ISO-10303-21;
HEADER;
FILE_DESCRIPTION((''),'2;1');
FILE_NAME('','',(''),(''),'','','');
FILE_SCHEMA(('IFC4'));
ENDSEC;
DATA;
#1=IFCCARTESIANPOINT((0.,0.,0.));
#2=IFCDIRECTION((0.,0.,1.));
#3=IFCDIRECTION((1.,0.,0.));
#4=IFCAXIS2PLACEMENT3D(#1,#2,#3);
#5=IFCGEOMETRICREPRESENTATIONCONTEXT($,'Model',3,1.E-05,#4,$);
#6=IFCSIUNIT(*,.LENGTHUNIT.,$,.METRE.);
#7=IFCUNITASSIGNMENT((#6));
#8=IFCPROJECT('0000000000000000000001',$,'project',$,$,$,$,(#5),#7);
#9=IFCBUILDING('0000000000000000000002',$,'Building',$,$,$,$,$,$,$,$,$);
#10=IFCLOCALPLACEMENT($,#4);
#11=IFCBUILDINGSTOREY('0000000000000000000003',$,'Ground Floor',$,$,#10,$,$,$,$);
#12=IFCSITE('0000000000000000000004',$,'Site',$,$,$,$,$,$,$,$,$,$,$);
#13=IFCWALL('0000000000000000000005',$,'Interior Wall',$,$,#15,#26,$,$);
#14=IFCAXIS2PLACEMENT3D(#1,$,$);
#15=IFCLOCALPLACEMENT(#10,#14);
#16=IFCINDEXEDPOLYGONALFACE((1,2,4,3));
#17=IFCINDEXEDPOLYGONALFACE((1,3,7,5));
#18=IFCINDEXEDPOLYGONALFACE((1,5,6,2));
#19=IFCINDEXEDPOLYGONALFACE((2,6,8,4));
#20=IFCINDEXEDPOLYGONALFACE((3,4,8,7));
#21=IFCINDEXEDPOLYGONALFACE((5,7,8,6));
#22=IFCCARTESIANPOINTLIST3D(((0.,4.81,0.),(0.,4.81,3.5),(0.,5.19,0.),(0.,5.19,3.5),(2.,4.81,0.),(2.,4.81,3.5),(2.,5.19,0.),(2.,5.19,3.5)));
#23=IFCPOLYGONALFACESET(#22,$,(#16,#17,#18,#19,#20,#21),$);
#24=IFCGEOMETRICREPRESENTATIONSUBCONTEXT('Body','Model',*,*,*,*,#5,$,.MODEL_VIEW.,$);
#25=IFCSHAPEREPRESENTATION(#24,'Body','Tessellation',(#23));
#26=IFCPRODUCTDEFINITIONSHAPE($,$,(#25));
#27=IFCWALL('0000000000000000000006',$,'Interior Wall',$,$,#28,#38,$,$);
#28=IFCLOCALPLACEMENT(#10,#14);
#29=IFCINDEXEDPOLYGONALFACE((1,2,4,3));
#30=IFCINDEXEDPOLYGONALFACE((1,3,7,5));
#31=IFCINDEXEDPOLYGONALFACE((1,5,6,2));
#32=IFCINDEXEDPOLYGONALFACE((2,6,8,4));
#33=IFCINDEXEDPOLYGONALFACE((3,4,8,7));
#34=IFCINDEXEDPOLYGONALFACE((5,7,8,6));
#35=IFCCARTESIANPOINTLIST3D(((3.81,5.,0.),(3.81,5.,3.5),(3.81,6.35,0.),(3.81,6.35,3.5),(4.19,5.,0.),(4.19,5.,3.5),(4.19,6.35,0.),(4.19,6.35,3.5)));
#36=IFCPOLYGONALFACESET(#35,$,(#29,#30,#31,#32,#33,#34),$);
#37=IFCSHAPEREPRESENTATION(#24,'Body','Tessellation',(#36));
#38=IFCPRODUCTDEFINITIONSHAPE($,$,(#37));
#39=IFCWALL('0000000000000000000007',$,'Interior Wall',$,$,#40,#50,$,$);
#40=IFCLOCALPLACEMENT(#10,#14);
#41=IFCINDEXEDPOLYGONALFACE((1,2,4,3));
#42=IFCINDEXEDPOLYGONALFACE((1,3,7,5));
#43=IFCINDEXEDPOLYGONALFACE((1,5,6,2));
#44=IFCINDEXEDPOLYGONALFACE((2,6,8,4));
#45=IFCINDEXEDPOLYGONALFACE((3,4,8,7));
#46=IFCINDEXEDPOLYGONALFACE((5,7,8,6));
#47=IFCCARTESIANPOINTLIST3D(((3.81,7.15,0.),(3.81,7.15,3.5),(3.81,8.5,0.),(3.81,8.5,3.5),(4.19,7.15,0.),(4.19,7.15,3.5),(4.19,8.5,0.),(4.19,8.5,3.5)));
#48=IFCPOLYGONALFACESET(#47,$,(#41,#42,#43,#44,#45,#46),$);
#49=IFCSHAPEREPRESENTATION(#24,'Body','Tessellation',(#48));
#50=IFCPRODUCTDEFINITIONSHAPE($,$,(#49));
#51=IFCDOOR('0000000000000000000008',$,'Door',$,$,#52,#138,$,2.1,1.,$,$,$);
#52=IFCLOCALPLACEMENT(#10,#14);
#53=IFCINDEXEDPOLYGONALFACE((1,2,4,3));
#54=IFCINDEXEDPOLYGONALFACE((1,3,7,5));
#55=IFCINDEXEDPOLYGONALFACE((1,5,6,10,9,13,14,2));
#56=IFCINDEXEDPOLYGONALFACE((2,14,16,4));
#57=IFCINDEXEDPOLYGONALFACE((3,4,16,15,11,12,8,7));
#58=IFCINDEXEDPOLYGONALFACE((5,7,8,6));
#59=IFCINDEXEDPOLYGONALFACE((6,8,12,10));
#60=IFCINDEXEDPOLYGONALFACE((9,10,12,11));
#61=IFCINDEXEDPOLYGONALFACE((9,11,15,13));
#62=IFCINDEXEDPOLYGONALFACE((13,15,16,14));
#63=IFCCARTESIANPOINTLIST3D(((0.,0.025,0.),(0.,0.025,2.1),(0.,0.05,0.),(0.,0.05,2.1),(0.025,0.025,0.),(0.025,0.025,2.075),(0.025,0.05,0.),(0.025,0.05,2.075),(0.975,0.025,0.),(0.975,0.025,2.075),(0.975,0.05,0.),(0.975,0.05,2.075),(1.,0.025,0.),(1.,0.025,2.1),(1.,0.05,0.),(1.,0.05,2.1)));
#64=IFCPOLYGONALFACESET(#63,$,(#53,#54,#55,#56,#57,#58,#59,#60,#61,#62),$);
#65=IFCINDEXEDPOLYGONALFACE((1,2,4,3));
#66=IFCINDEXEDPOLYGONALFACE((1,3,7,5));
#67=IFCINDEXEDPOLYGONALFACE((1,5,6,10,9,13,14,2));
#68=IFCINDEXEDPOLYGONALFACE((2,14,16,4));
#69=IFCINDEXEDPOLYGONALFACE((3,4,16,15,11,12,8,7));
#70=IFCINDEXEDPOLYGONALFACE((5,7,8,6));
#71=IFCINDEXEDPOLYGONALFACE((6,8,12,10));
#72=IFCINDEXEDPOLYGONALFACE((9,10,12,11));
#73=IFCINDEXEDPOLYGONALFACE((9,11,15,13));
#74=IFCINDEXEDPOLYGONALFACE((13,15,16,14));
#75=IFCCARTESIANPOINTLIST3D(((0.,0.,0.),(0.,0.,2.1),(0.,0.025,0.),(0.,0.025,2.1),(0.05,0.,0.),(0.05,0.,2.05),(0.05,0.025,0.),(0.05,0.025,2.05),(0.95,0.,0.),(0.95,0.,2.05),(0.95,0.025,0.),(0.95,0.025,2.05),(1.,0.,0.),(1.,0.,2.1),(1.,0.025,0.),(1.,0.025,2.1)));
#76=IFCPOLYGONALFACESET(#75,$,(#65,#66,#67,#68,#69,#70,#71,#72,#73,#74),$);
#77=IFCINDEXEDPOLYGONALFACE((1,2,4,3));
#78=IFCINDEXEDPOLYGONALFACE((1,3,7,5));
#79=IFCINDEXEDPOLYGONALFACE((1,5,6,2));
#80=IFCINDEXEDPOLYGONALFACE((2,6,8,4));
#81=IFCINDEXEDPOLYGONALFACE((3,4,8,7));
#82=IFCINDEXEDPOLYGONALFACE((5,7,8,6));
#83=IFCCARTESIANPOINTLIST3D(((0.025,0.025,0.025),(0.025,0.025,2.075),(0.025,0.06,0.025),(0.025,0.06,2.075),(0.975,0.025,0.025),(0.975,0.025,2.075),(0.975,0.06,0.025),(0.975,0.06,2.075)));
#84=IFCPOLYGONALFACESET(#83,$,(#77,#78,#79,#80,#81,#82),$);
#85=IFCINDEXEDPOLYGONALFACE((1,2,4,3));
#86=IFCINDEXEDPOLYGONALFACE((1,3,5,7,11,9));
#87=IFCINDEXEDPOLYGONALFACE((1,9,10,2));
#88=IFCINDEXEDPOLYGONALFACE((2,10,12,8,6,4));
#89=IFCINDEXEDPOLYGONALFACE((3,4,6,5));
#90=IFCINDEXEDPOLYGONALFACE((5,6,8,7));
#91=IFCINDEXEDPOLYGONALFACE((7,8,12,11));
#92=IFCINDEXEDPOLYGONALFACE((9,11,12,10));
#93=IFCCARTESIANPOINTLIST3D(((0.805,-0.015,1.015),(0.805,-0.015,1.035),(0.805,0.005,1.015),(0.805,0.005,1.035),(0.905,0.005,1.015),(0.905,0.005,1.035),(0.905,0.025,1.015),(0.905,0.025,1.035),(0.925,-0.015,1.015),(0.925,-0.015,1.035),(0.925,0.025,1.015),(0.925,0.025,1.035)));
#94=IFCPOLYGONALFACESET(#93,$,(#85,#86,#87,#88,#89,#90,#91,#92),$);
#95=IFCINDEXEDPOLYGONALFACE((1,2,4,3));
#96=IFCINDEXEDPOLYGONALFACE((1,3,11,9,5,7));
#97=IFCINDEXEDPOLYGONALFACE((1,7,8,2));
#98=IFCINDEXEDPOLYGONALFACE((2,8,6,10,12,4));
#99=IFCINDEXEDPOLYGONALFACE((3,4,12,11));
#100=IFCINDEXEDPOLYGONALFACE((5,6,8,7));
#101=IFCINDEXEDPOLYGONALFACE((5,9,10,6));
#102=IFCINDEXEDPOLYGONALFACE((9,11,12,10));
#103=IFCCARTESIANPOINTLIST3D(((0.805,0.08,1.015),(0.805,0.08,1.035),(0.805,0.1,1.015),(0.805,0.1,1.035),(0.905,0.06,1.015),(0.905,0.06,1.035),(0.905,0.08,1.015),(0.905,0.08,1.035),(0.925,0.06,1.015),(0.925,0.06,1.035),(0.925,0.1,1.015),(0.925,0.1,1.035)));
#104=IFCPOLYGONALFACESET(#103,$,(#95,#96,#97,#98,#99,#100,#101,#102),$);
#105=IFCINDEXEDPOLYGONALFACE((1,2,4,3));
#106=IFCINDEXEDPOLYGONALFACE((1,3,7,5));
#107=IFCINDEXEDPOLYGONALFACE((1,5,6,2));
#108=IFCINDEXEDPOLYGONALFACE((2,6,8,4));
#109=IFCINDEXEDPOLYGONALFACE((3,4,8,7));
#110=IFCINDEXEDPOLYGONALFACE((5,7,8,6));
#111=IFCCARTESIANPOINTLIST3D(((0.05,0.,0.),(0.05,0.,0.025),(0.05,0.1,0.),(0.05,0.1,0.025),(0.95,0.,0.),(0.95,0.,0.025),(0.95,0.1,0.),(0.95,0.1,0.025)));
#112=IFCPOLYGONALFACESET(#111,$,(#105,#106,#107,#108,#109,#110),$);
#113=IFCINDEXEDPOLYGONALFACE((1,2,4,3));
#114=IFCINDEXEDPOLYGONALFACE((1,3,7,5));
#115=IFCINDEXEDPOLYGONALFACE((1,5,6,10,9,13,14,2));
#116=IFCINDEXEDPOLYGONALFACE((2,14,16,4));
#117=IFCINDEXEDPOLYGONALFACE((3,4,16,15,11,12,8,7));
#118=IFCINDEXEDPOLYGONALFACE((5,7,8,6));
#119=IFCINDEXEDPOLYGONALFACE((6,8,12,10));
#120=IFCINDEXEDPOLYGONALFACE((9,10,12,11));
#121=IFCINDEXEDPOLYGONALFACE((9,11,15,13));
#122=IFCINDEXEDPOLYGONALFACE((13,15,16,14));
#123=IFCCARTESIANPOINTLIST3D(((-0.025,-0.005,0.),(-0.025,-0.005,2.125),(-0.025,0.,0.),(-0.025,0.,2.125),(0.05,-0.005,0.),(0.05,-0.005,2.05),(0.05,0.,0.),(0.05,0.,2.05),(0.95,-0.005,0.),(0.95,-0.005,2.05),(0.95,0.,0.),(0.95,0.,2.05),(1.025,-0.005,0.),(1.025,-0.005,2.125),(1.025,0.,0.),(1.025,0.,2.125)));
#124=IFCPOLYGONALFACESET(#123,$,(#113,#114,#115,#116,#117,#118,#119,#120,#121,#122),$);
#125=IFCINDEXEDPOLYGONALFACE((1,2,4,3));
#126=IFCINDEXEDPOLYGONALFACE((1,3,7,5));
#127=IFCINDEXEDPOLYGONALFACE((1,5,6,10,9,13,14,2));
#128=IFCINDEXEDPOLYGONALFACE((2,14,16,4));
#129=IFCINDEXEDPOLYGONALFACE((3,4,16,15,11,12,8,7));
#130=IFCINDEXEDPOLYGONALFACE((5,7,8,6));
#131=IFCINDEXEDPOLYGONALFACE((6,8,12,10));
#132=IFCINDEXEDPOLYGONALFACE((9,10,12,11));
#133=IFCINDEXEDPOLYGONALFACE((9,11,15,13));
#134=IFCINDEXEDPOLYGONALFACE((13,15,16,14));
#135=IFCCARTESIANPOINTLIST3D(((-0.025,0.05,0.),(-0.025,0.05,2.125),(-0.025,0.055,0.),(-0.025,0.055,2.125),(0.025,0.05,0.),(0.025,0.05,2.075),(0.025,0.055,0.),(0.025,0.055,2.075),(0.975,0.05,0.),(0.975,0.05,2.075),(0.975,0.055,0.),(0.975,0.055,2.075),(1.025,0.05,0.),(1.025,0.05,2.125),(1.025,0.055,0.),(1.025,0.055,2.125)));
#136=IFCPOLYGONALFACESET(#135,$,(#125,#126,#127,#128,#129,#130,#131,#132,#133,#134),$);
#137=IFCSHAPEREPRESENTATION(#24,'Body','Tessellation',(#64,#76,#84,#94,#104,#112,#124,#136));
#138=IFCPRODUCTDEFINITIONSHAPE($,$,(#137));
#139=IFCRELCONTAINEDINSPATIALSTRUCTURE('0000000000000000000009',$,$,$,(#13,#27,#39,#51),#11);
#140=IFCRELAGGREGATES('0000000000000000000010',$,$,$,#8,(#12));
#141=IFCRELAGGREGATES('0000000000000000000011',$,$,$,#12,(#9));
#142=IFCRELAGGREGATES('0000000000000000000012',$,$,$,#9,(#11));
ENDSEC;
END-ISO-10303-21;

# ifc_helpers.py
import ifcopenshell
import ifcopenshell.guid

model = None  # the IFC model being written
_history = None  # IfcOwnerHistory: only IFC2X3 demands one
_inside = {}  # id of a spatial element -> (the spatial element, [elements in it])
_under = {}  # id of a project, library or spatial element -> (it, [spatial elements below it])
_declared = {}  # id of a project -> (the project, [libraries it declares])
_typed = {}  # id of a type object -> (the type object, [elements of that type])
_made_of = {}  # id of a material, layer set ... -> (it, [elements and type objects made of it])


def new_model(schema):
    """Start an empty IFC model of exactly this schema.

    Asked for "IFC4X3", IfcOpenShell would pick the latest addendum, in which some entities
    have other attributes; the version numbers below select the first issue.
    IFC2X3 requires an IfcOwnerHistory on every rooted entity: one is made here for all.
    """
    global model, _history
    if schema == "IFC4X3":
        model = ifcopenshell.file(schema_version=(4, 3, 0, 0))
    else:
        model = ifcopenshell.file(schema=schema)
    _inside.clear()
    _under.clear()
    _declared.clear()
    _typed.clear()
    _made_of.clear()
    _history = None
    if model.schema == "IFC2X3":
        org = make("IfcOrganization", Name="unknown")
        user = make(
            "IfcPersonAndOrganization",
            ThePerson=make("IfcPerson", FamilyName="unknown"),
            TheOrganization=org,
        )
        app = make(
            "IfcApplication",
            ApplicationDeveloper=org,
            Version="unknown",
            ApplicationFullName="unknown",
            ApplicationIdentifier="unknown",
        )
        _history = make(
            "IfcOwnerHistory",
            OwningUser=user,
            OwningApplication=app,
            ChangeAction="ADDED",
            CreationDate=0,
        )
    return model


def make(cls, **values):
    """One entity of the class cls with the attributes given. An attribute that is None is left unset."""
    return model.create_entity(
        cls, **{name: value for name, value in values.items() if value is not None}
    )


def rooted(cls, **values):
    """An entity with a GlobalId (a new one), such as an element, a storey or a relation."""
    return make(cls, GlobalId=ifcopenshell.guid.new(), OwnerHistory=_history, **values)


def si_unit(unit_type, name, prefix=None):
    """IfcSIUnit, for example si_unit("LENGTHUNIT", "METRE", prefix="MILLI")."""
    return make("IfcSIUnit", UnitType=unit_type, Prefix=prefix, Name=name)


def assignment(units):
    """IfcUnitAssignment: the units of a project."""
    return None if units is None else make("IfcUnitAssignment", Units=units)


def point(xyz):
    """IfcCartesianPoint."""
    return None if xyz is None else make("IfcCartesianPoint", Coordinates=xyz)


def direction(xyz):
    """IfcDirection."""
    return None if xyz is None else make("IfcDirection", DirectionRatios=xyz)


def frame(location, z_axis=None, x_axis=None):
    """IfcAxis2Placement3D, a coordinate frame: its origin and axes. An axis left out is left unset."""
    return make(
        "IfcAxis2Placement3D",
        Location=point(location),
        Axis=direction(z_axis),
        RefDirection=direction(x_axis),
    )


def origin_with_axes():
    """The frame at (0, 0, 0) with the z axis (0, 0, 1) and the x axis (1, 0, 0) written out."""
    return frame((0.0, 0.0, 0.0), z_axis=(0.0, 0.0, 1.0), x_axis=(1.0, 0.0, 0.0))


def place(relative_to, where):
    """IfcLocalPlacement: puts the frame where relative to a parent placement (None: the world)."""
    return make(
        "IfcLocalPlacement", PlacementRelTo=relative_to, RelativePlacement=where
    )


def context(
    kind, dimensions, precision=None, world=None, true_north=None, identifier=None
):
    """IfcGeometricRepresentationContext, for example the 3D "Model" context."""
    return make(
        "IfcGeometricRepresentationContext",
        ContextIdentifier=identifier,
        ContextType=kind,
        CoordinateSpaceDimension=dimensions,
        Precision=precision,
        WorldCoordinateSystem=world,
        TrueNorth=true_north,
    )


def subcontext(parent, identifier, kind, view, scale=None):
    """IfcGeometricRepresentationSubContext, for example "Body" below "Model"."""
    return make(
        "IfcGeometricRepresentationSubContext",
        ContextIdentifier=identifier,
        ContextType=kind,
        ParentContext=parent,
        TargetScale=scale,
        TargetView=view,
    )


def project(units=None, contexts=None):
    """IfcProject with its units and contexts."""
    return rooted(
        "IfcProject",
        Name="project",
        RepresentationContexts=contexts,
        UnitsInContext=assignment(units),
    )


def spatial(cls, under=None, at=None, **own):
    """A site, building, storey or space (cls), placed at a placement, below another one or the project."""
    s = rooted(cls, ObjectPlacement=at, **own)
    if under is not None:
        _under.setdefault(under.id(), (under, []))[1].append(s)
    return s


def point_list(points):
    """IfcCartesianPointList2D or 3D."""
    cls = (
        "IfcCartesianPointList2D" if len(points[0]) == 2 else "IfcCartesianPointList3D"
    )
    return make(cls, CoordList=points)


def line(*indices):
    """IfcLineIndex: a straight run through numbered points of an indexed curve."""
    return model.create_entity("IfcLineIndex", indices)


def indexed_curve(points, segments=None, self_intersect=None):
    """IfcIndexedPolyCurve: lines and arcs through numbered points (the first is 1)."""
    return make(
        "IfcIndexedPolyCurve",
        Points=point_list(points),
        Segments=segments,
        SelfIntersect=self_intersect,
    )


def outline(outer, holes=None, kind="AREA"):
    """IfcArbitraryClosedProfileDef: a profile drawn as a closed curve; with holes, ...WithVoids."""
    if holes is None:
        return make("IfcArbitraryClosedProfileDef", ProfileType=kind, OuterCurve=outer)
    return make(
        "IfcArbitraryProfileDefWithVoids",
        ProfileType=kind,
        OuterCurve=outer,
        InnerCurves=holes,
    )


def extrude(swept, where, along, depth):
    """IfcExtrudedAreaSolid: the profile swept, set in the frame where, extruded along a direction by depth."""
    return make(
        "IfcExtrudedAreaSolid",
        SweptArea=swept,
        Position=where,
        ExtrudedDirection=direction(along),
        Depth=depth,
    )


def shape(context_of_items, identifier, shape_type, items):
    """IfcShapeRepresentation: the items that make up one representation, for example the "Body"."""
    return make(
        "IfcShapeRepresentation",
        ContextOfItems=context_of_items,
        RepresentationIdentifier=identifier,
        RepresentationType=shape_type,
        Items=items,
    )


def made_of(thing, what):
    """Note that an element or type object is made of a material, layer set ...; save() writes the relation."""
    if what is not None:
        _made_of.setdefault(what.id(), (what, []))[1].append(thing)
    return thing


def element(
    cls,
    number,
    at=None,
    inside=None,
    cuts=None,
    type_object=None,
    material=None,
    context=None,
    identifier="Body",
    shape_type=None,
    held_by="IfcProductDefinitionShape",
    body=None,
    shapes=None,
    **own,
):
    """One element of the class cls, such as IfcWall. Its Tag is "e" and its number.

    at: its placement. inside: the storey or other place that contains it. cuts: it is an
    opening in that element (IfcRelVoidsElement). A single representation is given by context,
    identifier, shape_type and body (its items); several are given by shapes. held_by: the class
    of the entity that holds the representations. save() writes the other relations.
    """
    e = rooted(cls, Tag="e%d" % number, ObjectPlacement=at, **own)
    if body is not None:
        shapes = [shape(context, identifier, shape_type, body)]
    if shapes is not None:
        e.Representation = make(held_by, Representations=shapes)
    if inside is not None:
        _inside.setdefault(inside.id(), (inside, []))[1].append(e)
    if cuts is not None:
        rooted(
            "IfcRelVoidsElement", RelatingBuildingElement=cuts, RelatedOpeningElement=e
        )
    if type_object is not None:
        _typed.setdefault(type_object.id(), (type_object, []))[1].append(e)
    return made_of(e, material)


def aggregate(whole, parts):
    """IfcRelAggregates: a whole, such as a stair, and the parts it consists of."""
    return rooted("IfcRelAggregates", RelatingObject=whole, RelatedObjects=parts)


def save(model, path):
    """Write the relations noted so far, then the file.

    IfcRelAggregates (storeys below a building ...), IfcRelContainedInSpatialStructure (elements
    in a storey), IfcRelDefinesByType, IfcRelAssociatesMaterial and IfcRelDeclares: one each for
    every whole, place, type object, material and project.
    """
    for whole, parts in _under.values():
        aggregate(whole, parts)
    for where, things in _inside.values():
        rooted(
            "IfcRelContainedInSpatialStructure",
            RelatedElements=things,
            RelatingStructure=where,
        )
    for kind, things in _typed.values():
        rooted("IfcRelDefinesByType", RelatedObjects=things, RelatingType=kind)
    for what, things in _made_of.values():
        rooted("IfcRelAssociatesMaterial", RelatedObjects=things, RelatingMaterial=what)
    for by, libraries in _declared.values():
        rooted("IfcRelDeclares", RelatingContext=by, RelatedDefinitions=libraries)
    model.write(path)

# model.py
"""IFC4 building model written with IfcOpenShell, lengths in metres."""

from ifc_helpers import new_model, si_unit, frame, origin_with_axes, place, context, subcontext, project, spatial, line, indexed_curve, outline, extrude, element, save


model = new_model("IFC4")

# Units and contexts
model_context = context("Model", 3, precision=1e-05, world=origin_with_axes())
body_context = subcontext(model_context, "Body", "Model", "MODEL_VIEW")
ifc_project = project(units=[si_unit("LENGTHUNIT", "METRE")], contexts=[model_context])

# Site, building, storey
site = spatial("IfcSite", under=ifc_project, Name="Site")
building = spatial("IfcBuilding", under=site, Name="Building")
storey_placement = place(None, origin_with_axes())
storey = spatial("IfcBuildingStorey", under=building, at=storey_placement, Name="Ground Floor")

# Walls
wall_1_placement = place(storey_placement, frame((2.0, 5.0, 0.0), z_axis=(0.0, 0.0, 1.0), x_axis=(-1.0, 0.0, 0.0)))
element("IfcWall", 1, at=wall_1_placement, inside=storey, Name="Interior Wall", context=body_context, shape_type="SweptSolid", body=[
    extrude(outline(indexed_curve([(0.0, 0.0), (0.0, 0.38), (2.0, 0.38), (2.0, 0.0), (0.0, 0.0)], self_intersect=False)), frame((0.0, -0.19, 0.0), z_axis=(0.0, 0.0, 1.0), x_axis=(1.0, 0.0, 0.0)), (0.0, 0.0, 1.0), 3.5),
])
for number, where, z_axis, x_axis, name in (
    (2, (4.0, 5.0, 0.0), (0.0, 0.0, 1.0), (0.0, 1.0, 0.0), "Interior Wall"),
    (3, (4.0, 7.15, 0.0), (0.0, 0.0, 1.0), (0.0, 1.0, 0.0), "Interior Wall"),
):
    element("IfcWall", number, at=place(storey_placement, frame(where, z_axis=z_axis, x_axis=x_axis)), inside=storey, Name=name, context=body_context, shape_type="SweptSolid", body=[
        extrude(outline(indexed_curve([(0.0, 0.0), (0.0, 0.38), (1.35, 0.38), (1.35, 0.0), (0.0, 0.0)], self_intersect=False)), frame((0.0, -0.19, 0.0), z_axis=(0.0, 0.0, 1.0), x_axis=(1.0, 0.0, 0.0)), (0.0, 0.0, 1.0), 3.5),
    ])

# Door
door_1_placement = place(storey_placement, origin_with_axes())
element("IfcDoor", 4, at=door_1_placement, inside=storey, Name="Door", OverallHeight=2.1, OverallWidth=1.0, context=body_context, shape_type="SweptSolid", body=[
    extrude(outline(indexed_curve([(0.0, 0.0), (0.0, 2.1), (1.0, 2.1), (1.0, 0.0), (0.975, 0.0), (0.975, 2.075), (0.025, 2.075), (0.025, 0.0)], segments=[line(1, 2, 3, 4, 5, 6, 7, 8, 1)])), frame((0.0, 0.025, 0.0), z_axis=(0.0, -1.0, 0.0), x_axis=(1.0, 0.0, 0.0)), (0.0, 0.0, -1.0), 0.025),
    extrude(outline(indexed_curve([(0.0, 0.0), (0.0, 2.1), (1.0, 2.1), (1.0, 0.0), (0.95, 0.0), (0.95, 2.05), (0.05, 2.05), (0.05, 0.0)], segments=[line(1, 2, 3, 4, 5, 6, 7, 8, 1)])), frame((0.0, 0.0, 0.0), z_axis=(0.0, -1.0, 0.0), x_axis=(1.0, 0.0, 0.0)), (0.0, 0.0, -1.0), 0.025),
    extrude(outline(indexed_curve([(0.0, 0.0), (0.95, 0.0), (0.95, 0.035), (0.0, 0.035)], segments=[line(1, 2, 3, 4, 1)])), frame((0.025, 0.025, 0.025), z_axis=(0.0, 0.0, 1.0), x_axis=(1.0, 0.0, 0.0)), (0.0, 0.0, 1.0), 2.05),
    extrude(outline(indexed_curve([(0.0, 0.0), (0.0, -0.04), (-0.12, -0.04), (-0.12, -0.02), (-0.02, -0.02), (-0.02, 0.0)], segments=[line(1, 2, 3, 4, 5, 6, 1)])), frame((0.925, 0.025, 1.015), z_axis=(0.0, 0.0, 1.0), x_axis=(1.0, 0.0, 0.0)), (0.0, 0.0, 1.0), 0.02),
    extrude(outline(indexed_curve([(0.0, 0.0), (0.0, 0.04), (-0.12, 0.04), (-0.12, 0.02), (-0.02, 0.02), (-0.02, 0.0)], segments=[line(1, 2, 3, 4, 5, 6, 1)])), frame((0.925, 0.06, 1.015), z_axis=(0.0, 0.0, 1.0), x_axis=(1.0, 0.0, 0.0)), (0.0, 0.0, 1.0), 0.02),
    extrude(outline(indexed_curve([(0.0, 0.0), (0.9, 0.0), (0.9, 0.1), (0.0, 0.1)], segments=[line(1, 2, 3, 4, 1)])), frame((0.05, 0.0, 0.0), z_axis=(0.0, 0.0, 1.0), x_axis=(1.0, 0.0, 0.0)), (0.0, 0.0, 1.0), 0.025),
    extrude(outline(indexed_curve([(0.0, 0.0), (0.0, 2.125), (1.05, 2.125), (1.05, 0.0), (0.975, 0.0), (0.975, 2.05), (0.075, 2.05), (0.075, 0.0)], segments=[line(1, 2, 3, 4, 5, 6, 7, 8, 1)])), frame((-0.025, -0.005, 0.0), z_axis=(0.0, -1.0, 0.0), x_axis=(1.0, 0.0, 0.0)), (0.0, 0.0, -1.0), 0.005),
    extrude(outline(indexed_curve([(0.0, 0.0), (0.0, 2.125), (1.05, 2.125), (1.05, 0.0), (1.0, 0.0), (1.0, 2.075), (0.05, 2.075), (0.05, 0.0)], segments=[line(1, 2, 3, 4, 5, 6, 7, 8, 1)])), frame((-0.025, 0.05, 0.0), z_axis=(0.0, -1.0, 0.0), x_axis=(1.0, 0.0, 0.0)), (0.0, 0.0, -1.0), 0.005),
])

save(model, "model.ifc")
